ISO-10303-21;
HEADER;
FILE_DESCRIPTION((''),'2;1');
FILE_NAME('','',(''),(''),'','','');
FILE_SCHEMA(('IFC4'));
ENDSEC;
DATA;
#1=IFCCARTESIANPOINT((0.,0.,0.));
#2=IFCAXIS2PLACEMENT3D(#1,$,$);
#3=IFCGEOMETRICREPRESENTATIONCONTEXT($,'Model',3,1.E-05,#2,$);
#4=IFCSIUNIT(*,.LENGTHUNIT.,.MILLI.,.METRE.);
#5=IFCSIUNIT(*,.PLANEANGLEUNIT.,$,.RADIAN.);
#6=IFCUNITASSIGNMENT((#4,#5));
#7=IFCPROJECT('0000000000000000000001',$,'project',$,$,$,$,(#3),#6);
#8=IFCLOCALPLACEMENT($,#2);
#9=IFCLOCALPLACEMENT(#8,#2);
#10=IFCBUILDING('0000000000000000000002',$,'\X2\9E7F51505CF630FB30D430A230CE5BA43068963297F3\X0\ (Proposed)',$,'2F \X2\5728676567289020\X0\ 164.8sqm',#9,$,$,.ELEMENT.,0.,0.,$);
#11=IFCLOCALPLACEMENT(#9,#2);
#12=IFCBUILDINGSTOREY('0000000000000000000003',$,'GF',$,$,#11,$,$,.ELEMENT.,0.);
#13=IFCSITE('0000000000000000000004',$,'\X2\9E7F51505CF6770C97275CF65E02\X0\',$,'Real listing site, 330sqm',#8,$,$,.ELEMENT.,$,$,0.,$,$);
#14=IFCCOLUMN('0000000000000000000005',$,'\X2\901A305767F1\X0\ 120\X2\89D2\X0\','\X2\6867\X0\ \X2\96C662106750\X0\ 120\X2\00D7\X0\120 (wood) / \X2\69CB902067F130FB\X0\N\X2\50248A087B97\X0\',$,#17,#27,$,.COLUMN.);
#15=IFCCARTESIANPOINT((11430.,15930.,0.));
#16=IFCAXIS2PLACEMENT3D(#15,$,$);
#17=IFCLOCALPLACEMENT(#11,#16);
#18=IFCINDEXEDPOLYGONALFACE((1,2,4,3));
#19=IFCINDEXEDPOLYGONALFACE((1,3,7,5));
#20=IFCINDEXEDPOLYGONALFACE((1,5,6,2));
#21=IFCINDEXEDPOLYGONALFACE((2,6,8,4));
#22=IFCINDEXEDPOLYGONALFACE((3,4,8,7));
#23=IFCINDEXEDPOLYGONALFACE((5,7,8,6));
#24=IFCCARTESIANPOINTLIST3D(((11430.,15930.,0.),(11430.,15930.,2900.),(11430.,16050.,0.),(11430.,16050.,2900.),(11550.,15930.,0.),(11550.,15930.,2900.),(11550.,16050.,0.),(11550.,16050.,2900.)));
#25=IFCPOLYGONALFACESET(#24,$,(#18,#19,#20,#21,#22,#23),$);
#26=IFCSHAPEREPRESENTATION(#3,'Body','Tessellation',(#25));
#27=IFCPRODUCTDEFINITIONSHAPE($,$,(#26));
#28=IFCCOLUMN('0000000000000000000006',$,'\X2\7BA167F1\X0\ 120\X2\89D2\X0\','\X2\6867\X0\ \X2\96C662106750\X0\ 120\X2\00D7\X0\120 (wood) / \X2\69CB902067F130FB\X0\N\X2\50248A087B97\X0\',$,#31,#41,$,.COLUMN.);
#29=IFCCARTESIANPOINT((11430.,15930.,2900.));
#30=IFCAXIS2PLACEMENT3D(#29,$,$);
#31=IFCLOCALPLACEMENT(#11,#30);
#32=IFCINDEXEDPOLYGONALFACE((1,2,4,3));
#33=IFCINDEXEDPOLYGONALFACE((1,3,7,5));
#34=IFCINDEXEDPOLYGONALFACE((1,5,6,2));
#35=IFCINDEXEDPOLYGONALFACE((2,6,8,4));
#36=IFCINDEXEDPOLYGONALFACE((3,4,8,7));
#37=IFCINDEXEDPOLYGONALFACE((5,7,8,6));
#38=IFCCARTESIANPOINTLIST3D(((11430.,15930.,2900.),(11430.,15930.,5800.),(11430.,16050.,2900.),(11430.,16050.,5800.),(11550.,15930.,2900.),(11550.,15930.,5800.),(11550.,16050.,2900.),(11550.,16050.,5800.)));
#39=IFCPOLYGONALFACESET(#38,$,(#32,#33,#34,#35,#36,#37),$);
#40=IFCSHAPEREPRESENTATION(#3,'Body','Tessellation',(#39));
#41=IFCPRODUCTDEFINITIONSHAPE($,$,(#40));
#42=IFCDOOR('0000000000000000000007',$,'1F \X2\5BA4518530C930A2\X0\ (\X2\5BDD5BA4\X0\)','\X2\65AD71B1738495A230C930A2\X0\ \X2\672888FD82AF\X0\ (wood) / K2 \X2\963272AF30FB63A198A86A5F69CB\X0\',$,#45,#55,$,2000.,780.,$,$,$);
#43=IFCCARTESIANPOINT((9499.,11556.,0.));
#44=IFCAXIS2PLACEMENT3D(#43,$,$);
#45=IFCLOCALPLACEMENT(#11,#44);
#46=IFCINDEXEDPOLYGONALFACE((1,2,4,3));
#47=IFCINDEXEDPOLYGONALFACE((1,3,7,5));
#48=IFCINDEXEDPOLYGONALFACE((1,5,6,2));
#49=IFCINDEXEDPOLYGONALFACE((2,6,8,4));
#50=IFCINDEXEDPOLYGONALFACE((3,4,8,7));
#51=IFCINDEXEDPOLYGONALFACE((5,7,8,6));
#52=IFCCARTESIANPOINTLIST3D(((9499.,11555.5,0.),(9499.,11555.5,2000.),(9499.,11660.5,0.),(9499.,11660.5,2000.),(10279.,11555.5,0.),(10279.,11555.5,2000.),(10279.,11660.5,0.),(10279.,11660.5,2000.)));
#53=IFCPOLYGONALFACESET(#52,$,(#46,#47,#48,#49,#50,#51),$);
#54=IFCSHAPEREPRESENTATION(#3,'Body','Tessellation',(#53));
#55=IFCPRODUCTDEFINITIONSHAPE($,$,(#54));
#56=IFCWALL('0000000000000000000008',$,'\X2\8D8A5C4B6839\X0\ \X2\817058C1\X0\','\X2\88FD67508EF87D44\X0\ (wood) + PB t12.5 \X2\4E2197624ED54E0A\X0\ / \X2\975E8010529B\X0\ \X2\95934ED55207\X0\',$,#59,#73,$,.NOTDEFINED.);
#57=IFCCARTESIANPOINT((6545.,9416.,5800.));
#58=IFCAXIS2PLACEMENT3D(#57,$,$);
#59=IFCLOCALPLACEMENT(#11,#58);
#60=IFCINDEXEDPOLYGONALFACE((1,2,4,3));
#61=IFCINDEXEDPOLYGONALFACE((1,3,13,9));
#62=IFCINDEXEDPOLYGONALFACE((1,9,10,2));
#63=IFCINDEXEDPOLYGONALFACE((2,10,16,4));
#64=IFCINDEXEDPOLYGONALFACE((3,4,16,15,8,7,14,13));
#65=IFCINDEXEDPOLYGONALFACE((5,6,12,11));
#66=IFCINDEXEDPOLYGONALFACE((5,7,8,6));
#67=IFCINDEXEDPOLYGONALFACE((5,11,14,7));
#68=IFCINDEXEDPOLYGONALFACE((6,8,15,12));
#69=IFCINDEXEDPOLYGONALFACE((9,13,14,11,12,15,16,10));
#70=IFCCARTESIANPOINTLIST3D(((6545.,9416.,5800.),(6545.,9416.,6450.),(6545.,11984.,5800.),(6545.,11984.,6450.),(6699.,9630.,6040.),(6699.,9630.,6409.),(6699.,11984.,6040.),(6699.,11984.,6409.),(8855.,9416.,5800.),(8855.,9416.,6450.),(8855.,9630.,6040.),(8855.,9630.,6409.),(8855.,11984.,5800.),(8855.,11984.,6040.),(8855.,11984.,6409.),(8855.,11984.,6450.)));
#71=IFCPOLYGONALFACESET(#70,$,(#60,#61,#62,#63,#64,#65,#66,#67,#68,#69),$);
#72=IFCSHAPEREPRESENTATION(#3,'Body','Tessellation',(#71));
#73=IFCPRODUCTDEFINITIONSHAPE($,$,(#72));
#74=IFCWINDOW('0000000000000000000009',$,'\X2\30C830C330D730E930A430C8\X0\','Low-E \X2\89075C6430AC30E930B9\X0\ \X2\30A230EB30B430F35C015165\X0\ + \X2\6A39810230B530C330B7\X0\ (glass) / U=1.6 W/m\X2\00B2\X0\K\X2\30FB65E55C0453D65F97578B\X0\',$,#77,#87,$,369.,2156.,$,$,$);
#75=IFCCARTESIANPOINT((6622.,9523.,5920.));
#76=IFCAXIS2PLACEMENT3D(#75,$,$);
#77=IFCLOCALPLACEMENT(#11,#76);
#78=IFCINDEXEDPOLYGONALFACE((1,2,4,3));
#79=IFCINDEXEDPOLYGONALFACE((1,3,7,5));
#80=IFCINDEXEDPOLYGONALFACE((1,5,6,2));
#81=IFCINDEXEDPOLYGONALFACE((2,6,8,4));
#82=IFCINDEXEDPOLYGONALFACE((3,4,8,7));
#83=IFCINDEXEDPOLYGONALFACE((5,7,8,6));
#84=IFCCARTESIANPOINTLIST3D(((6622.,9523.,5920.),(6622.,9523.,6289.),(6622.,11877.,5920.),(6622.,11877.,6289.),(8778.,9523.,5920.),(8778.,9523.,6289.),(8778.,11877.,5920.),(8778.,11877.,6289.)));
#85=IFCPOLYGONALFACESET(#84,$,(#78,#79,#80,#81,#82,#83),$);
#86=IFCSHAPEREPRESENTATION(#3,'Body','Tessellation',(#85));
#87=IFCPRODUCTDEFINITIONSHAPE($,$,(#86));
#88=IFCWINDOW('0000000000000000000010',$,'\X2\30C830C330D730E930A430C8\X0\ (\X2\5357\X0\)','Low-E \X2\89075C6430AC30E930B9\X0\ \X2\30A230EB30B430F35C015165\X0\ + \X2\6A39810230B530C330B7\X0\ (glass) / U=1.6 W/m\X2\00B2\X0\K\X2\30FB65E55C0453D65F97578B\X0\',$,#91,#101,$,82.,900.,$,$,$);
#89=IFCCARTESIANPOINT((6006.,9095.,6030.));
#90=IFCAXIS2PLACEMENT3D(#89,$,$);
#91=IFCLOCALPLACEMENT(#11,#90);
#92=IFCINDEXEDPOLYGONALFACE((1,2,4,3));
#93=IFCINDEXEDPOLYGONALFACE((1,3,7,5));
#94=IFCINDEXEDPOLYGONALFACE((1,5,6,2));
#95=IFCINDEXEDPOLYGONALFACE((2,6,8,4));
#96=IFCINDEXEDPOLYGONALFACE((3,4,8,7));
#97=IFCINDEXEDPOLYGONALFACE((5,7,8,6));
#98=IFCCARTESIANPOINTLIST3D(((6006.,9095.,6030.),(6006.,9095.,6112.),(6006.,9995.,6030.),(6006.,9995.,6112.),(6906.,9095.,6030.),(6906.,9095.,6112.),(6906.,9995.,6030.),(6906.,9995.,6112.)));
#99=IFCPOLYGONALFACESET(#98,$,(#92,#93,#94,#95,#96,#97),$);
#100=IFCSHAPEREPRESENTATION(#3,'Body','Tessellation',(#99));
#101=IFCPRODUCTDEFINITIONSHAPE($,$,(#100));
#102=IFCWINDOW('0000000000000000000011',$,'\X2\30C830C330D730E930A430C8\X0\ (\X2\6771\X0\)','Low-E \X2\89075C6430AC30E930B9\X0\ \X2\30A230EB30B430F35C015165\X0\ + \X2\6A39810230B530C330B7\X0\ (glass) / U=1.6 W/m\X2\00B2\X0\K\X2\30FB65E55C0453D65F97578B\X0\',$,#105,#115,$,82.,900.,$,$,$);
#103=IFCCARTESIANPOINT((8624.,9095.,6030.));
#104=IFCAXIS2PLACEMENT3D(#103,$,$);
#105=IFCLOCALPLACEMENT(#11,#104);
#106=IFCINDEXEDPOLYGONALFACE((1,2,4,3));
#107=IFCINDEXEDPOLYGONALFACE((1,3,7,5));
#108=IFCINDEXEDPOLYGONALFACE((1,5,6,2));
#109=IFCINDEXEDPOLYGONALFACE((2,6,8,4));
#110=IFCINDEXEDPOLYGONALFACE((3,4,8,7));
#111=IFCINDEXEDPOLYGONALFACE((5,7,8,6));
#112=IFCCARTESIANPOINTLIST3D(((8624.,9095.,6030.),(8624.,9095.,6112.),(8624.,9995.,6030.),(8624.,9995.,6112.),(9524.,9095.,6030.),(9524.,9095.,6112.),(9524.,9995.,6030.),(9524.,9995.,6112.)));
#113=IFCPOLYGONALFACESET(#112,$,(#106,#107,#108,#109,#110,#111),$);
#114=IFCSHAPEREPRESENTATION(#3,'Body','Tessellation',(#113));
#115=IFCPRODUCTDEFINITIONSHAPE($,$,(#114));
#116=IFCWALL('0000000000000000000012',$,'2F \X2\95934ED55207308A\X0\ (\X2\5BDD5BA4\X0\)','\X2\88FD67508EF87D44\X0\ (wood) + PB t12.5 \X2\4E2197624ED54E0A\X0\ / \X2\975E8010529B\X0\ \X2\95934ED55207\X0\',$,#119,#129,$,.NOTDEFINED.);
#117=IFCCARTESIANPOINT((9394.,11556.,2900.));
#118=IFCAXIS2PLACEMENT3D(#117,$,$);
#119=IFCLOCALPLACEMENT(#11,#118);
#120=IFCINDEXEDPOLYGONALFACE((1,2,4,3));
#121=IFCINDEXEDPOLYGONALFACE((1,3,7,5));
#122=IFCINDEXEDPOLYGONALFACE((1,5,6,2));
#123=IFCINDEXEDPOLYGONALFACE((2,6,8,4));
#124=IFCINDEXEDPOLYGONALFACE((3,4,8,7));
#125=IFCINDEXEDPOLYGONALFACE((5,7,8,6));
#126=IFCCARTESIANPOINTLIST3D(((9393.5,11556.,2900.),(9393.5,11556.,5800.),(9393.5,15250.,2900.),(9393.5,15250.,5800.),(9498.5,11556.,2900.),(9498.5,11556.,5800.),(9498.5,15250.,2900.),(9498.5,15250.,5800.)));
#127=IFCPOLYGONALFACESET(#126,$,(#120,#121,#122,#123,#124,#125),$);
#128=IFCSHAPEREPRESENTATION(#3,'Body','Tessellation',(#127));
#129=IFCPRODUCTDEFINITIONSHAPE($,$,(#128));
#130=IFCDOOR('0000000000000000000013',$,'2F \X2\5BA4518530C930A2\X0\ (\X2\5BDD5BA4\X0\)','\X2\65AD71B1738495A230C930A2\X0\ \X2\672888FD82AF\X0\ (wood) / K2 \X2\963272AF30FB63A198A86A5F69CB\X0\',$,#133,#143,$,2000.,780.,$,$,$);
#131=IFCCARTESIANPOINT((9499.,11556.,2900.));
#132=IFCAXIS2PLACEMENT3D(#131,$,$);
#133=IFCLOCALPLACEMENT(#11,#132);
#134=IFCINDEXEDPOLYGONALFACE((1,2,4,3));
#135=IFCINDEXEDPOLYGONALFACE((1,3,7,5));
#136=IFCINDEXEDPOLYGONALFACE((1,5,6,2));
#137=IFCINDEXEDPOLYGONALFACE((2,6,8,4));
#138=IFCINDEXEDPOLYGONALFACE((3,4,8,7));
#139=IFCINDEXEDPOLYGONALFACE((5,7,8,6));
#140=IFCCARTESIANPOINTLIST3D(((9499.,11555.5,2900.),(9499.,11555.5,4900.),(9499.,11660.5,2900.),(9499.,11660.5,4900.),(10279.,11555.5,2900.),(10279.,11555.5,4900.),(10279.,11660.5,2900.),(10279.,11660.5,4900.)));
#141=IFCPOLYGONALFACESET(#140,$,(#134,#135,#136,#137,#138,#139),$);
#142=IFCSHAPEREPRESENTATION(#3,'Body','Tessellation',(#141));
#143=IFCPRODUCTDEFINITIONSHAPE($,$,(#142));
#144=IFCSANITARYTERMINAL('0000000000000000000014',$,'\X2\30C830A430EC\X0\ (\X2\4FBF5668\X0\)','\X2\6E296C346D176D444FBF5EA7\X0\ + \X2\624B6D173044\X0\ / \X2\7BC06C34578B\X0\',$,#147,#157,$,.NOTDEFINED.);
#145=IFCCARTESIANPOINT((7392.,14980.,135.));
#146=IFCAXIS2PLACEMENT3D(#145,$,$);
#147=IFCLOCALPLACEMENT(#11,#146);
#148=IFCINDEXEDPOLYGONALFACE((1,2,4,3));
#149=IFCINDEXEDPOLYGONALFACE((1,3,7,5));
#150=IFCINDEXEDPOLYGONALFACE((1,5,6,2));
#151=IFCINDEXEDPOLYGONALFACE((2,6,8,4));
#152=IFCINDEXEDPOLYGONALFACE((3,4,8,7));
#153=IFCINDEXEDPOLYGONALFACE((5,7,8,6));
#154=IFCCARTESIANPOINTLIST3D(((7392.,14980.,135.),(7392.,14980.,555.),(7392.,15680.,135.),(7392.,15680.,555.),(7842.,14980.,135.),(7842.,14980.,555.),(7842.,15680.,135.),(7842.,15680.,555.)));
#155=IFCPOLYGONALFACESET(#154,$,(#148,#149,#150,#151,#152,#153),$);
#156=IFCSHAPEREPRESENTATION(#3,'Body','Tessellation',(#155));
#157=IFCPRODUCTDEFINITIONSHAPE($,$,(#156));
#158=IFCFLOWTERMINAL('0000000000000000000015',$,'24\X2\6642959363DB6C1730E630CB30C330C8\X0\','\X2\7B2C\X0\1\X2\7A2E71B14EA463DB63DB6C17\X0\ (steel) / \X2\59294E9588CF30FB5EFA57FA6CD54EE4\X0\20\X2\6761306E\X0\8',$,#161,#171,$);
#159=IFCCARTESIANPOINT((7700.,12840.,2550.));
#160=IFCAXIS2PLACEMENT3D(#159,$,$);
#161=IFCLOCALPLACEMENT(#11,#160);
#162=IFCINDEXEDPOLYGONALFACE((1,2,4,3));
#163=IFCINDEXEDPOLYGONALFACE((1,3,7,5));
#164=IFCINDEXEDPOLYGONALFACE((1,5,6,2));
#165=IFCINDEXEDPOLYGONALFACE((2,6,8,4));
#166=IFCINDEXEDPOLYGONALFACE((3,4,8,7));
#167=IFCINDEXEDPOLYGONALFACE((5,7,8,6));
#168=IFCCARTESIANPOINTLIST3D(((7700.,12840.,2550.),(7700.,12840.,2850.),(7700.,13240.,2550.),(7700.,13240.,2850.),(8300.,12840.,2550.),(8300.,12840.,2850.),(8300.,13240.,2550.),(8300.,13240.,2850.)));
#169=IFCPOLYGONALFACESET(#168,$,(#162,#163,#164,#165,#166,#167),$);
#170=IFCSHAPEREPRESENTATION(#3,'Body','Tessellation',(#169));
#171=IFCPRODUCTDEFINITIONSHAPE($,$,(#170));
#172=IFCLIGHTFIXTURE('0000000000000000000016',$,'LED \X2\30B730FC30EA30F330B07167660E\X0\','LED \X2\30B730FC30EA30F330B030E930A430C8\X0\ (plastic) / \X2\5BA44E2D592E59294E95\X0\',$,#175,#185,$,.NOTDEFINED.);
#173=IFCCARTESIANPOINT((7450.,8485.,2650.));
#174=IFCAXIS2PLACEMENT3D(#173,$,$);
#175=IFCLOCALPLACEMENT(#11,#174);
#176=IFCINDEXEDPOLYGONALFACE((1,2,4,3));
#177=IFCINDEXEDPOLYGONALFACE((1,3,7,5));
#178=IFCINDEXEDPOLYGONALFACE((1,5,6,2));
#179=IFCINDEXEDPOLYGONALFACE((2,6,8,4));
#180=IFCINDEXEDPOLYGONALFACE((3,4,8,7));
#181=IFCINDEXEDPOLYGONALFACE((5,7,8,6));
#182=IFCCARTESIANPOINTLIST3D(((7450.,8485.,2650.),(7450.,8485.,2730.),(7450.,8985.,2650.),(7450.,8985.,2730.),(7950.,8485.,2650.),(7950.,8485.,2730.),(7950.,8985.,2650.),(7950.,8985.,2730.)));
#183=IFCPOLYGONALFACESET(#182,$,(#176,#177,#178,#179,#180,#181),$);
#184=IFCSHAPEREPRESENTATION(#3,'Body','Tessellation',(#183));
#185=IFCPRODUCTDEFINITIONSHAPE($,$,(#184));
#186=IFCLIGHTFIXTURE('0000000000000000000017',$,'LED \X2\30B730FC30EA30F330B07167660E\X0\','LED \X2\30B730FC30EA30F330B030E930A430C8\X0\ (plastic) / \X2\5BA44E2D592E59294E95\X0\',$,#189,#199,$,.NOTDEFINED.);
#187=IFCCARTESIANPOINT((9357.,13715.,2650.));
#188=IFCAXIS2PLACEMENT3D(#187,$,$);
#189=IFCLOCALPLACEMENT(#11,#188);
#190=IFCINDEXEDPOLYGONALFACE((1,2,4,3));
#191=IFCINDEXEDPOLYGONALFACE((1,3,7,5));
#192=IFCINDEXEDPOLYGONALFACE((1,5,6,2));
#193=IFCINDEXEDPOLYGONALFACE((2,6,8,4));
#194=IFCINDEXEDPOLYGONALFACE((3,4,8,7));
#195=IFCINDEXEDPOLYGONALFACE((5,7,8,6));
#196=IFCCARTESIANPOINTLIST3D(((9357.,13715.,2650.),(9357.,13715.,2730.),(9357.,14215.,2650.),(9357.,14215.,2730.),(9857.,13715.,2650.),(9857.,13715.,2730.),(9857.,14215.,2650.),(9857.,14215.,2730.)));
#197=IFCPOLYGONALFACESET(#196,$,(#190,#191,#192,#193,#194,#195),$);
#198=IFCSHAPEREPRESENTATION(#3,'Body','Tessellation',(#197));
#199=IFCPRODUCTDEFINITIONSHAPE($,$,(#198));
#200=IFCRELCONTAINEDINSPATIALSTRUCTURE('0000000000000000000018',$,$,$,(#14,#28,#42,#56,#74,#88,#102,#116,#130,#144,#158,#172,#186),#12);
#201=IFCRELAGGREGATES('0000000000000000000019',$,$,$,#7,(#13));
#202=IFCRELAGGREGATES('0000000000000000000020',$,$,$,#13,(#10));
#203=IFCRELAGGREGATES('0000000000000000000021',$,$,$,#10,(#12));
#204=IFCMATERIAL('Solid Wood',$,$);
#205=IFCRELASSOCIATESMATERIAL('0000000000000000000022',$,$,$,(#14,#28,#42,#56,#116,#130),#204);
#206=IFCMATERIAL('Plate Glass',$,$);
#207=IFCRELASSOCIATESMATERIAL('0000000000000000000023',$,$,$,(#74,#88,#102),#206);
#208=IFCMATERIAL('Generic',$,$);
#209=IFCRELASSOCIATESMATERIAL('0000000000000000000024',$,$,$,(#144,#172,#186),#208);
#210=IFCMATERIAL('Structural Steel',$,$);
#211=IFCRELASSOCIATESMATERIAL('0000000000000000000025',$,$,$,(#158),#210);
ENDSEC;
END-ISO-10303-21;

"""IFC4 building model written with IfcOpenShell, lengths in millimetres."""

from ifc_helpers import new_model, si_unit, frame, frame_2d, origin, place, context, project, spatial, rectangle, extrude, material, element, fill, save


model = new_model("IFC4")

# Units and contexts
model_context = context("Model", 3, precision=1e-05, world=origin())
ifc_project = project(units=[si_unit("LENGTHUNIT", "METRE", prefix="MILLI"), si_unit("PLANEANGLEUNIT", "RADIAN")], contexts=[model_context])

# Site, building, storey
site_placement = place(None, origin())
site = spatial("IfcSite", under=ifc_project, at=site_placement, Name="鹿児島県霧島市", ObjectType="Real listing site, 330sqm", CompositionType="ELEMENT", RefElevation=0.0)
building_placement = place(site_placement, origin())
building = spatial("IfcBuilding", under=site, at=building_placement, Name="鹿児島・ピアノ室と防音 (Proposed)", ObjectType="2F 在来木造 164.8sqm", CompositionType="ELEMENT", ElevationOfRefHeight=0.0, ElevationOfTerrain=0.0)
storey_placement = place(building_placement, origin())
storey = spatial("IfcBuildingStorey", under=building, at=storey_placement, Name="GF", CompositionType="ELEMENT", Elevation=0.0)

# Columns
ifc_material_1 = material(Name="Solid Wood")
column_1_placement = place(storey_placement, frame((11430.0, 15930.0, 0.0)))
element("IfcColumn", 1, at=column_1_placement, inside=storey, material=ifc_material_1, Name="通し柱 120角", Description="桧 集成材 120×120 (wood) / 構造柱・N値計算", PredefinedType="COLUMN", context=model_context, shape_type="SweptSolid", body=[
    extrude(rectangle(XDim=120.0, YDim=120.0, at=frame_2d((60.0, 60.0))), frame((11430.0, 15930.0, 0.0)), (0.0, 0.0, 1.0), 2900.0),
])
column_2_placement = place(storey_placement, frame((11430.0, 15930.0, 2900.0)))
element("IfcColumn", 2, at=column_2_placement, inside=storey, material=ifc_material_1, Name="管柱 120角", Description="桧 集成材 120×120 (wood) / 構造柱・N値計算", PredefinedType="COLUMN", context=model_context, shape_type="SweptSolid", body=[
    extrude(rectangle(XDim=120.0, YDim=120.0, at=frame_2d((60.0, 60.0))), frame((11430.0, 15930.0, 2900.0)), (0.0, 0.0, 1.0), 2900.0),
])

# Door
door_1_placement = place(storey_placement, frame((9499.0, 11556.0, 0.0)))
element("IfcDoor", 3, at=door_1_placement, inside=storey, material=ifc_material_1, Name="1F 室内ドア (寝室)", Description="断熱玄関ドア 木製芯 (wood) / K2 防犯・採風機構", OverallHeight=2000.0, OverallWidth=780.0, context=model_context, shape_type="SweptSolid", body=[
    extrude(rectangle(XDim=780.0, YDim=105.0, at=frame_2d((390.0, 52.0))), frame((9499.0, 11556.0, 0.0)), (0.0, 0.0, 1.0), 2000.0),
])

# Wall, openings, windows
wall_1_placement = place(storey_placement, frame((6545.0, 9416.0, 5800.0)))
wall_1 = element("IfcWall", 4, at=wall_1_placement, inside=storey, material=ifc_material_1, Name="越屋根 腰壁", Description="製材軸組 (wood) + PB t12.5 両面仕上 / 非耐力 間仕切", PredefinedType="NOTDEFINED", context=model_context, shape_type="SweptSolid", body=[
    extrude(rectangle(XDim=2310.0, YDim=2568.0, at=frame_2d((1155.0, 1284.0))), frame((6545.0, 9416.0, 5800.0)), (0.0, 0.0, 1.0), 650.0),
])
opening_1_placement = place(storey_placement, frame((6622.0, 9523.0, 5920.0)))
opening_1 = element("IfcOpeningElement", 5, at=opening_1_placement, cuts=wall_1, PredefinedType="NOTDEFINED", context=model_context, shape_type="SweptSolid", body=[
    extrude(rectangle(XDim=2156.0, YDim=2354.0, at=frame_2d((1078.0, 1177.0))), frame((6622.0, 9523.0, 5920.0)), (0.0, 0.0, 1.0), 369.0),
])
opening_2_placement = place(storey_placement, frame((6006.0, 9095.0, 6030.0)))
opening_2 = element("IfcOpeningElement", 6, at=opening_2_placement, cuts=wall_1, PredefinedType="NOTDEFINED", context=model_context, shape_type="SweptSolid", body=[
    extrude(rectangle(XDim=900.0, YDim=900.0, at=frame_2d((450.0, 450.0))), frame((6006.0, 9095.0, 6030.0)), (0.0, 0.0, 1.0), 82.0),
])
opening_3_placement = place(storey_placement, frame((8624.0, 9095.0, 6030.0)))
opening_3 = element("IfcOpeningElement", 7, at=opening_3_placement, cuts=wall_1, PredefinedType="NOTDEFINED", context=model_context, shape_type="SweptSolid", body=[
    extrude(rectangle(XDim=900.0, YDim=900.0, at=frame_2d((450.0, 450.0))), frame((8624.0, 9095.0, 6030.0)), (0.0, 0.0, 1.0), 82.0),
])
ifc_material_2 = material(Name="Plate Glass")
window_1_placement = place(storey_placement, frame((6622.0, 9523.0, 5920.0)))
window_1 = element("IfcWindow", 8, at=window_1_placement, inside=storey, material=ifc_material_2, Name="トップライト", Description="Low-E 複層ガラス アルゴン封入 + 樹脂サッシ (glass) / U=1.6 W/m²K・日射取得型", OverallHeight=369.0, OverallWidth=2156.0, context=model_context, shape_type="SweptSolid", body=[
    extrude(rectangle(XDim=2156.0, YDim=2354.0, at=frame_2d((1078.0, 1177.0))), frame((6622.0, 9523.0, 5920.0)), (0.0, 0.0, 1.0), 369.0),
])
fill(opening_1, window_1)
window_2_placement = place(storey_placement, frame((6006.0, 9095.0, 6030.0)))
window_2 = element("IfcWindow", 9, at=window_2_placement, inside=storey, material=ifc_material_2, Name="トップライト (南)", Description="Low-E 複層ガラス アルゴン封入 + 樹脂サッシ (glass) / U=1.6 W/m²K・日射取得型", OverallHeight=82.0, OverallWidth=900.0, context=model_context, shape_type="SweptSolid", body=[
    extrude(rectangle(XDim=900.0, YDim=900.0, at=frame_2d((450.0, 450.0))), frame((6006.0, 9095.0, 6030.0)), (0.0, 0.0, 1.0), 82.0),
])
fill(opening_2, window_2)
window_3_placement = place(storey_placement, frame((8624.0, 9095.0, 6030.0)))
window_3 = element("IfcWindow", 10, at=window_3_placement, inside=storey, material=ifc_material_2, Name="トップライト (東)", Description="Low-E 複層ガラス アルゴン封入 + 樹脂サッシ (glass) / U=1.6 W/m²K・日射取得型", OverallHeight=82.0, OverallWidth=900.0, context=model_context, shape_type="SweptSolid", body=[
    extrude(rectangle(XDim=900.0, YDim=900.0, at=frame_2d((450.0, 450.0))), frame((8624.0, 9095.0, 6030.0)), (0.0, 0.0, 1.0), 82.0),
])
fill(opening_3, window_3)

# Wall
wall_2_placement = place(storey_placement, frame((9394.0, 11556.0, 2900.0)))
element("IfcWall", 11, at=wall_2_placement, inside=storey, material=ifc_material_1, Name="2F 間仕切り (寝室)", Description="製材軸組 (wood) + PB t12.5 両面仕上 / 非耐力 間仕切", PredefinedType="NOTDEFINED", context=model_context, shape_type="SweptSolid", body=[
    extrude(rectangle(XDim=105.0, YDim=3694.0, at=frame_2d((52.0, 1847.0))), frame((9394.0, 11556.0, 2900.0)), (0.0, 0.0, 1.0), 2900.0),
])

# Door
door_2_placement = place(storey_placement, frame((9499.0, 11556.0, 2900.0)))
element("IfcDoor", 12, at=door_2_placement, inside=storey, material=ifc_material_1, Name="2F 室内ドア (寝室)", Description="断熱玄関ドア 木製芯 (wood) / K2 防犯・採風機構", OverallHeight=2000.0, OverallWidth=780.0, context=model_context, shape_type="SweptSolid", body=[
    extrude(rectangle(XDim=780.0, YDim=105.0, at=frame_2d((390.0, 52.0))), frame((9499.0, 11556.0, 2900.0)), (0.0, 0.0, 1.0), 2000.0),
])

# Sanitary terminal
ifc_material_3 = material(Name="Generic")
sanitary_terminal_placement = place(storey_placement, frame((7392.0, 14980.0, 135.0)))
element("IfcSanitaryTerminal", 13, at=sanitary_terminal_placement, inside=storey, material=ifc_material_3, Name="トイレ (便器)", Description="温水洗浄便座 + 手洗い / 節水型", PredefinedType="NOTDEFINED", context=model_context, shape_type="SweptSolid", body=[
    extrude(rectangle(XDim=450.0, YDim=700.0, at=frame_2d((225.0, 350.0))), frame((7392.0, 14980.0, 135.0)), (0.0, 0.0, 1.0), 420.0),
])

# Flow terminal
ifc_material_4 = material(Name="Structural Steel")
flow_terminal_placement = place(storey_placement, frame((7700.0, 12840.0, 2550.0)))
element("IfcFlowTerminal", 14, at=flow_terminal_placement, inside=storey, material=ifc_material_4, Name="24時間換気ユニット", Description="第1種熱交換換気 (steel) / 天井裏・建基法令20条の8", context=model_context, shape_type="SweptSolid", body=[
    extrude(rectangle(XDim=600.0, YDim=400.0, at=frame_2d((300.0, 200.0))), frame((7700.0, 12840.0, 2550.0)), (0.0, 0.0, 1.0), 300.0),
])

# Light fixtures
light_fixture_1_placement = place(storey_placement, frame((7450.0, 8485.0, 2650.0)))
element("IfcLightFixture", 15, at=light_fixture_1_placement, inside=storey, material=ifc_material_3, Name="LED シーリング照明", Description="LED シーリングライト (plastic) / 室中央天井", PredefinedType="NOTDEFINED", context=model_context, shape_type="SweptSolid", body=[
    extrude(rectangle(XDim=500.0, YDim=500.0, at=frame_2d((250.0, 250.0))), frame((7450.0, 8485.0, 2650.0)), (0.0, 0.0, 1.0), 80.0),
])
light_fixture_2_placement = place(storey_placement, frame((9357.0, 13715.0, 2650.0)))
element("IfcLightFixture", 16, at=light_fixture_2_placement, inside=storey, material=ifc_material_3, Name="LED シーリング照明", Description="LED シーリングライト (plastic) / 室中央天井", PredefinedType="NOTDEFINED", context=model_context, shape_type="SweptSolid", body=[
    extrude(rectangle(XDim=500.0, YDim=500.0, at=frame_2d((250.0, 250.0))), frame((9357.0, 13715.0, 2650.0)), (0.0, 0.0, 1.0), 80.0),
])

save(model, "model.ifc")
